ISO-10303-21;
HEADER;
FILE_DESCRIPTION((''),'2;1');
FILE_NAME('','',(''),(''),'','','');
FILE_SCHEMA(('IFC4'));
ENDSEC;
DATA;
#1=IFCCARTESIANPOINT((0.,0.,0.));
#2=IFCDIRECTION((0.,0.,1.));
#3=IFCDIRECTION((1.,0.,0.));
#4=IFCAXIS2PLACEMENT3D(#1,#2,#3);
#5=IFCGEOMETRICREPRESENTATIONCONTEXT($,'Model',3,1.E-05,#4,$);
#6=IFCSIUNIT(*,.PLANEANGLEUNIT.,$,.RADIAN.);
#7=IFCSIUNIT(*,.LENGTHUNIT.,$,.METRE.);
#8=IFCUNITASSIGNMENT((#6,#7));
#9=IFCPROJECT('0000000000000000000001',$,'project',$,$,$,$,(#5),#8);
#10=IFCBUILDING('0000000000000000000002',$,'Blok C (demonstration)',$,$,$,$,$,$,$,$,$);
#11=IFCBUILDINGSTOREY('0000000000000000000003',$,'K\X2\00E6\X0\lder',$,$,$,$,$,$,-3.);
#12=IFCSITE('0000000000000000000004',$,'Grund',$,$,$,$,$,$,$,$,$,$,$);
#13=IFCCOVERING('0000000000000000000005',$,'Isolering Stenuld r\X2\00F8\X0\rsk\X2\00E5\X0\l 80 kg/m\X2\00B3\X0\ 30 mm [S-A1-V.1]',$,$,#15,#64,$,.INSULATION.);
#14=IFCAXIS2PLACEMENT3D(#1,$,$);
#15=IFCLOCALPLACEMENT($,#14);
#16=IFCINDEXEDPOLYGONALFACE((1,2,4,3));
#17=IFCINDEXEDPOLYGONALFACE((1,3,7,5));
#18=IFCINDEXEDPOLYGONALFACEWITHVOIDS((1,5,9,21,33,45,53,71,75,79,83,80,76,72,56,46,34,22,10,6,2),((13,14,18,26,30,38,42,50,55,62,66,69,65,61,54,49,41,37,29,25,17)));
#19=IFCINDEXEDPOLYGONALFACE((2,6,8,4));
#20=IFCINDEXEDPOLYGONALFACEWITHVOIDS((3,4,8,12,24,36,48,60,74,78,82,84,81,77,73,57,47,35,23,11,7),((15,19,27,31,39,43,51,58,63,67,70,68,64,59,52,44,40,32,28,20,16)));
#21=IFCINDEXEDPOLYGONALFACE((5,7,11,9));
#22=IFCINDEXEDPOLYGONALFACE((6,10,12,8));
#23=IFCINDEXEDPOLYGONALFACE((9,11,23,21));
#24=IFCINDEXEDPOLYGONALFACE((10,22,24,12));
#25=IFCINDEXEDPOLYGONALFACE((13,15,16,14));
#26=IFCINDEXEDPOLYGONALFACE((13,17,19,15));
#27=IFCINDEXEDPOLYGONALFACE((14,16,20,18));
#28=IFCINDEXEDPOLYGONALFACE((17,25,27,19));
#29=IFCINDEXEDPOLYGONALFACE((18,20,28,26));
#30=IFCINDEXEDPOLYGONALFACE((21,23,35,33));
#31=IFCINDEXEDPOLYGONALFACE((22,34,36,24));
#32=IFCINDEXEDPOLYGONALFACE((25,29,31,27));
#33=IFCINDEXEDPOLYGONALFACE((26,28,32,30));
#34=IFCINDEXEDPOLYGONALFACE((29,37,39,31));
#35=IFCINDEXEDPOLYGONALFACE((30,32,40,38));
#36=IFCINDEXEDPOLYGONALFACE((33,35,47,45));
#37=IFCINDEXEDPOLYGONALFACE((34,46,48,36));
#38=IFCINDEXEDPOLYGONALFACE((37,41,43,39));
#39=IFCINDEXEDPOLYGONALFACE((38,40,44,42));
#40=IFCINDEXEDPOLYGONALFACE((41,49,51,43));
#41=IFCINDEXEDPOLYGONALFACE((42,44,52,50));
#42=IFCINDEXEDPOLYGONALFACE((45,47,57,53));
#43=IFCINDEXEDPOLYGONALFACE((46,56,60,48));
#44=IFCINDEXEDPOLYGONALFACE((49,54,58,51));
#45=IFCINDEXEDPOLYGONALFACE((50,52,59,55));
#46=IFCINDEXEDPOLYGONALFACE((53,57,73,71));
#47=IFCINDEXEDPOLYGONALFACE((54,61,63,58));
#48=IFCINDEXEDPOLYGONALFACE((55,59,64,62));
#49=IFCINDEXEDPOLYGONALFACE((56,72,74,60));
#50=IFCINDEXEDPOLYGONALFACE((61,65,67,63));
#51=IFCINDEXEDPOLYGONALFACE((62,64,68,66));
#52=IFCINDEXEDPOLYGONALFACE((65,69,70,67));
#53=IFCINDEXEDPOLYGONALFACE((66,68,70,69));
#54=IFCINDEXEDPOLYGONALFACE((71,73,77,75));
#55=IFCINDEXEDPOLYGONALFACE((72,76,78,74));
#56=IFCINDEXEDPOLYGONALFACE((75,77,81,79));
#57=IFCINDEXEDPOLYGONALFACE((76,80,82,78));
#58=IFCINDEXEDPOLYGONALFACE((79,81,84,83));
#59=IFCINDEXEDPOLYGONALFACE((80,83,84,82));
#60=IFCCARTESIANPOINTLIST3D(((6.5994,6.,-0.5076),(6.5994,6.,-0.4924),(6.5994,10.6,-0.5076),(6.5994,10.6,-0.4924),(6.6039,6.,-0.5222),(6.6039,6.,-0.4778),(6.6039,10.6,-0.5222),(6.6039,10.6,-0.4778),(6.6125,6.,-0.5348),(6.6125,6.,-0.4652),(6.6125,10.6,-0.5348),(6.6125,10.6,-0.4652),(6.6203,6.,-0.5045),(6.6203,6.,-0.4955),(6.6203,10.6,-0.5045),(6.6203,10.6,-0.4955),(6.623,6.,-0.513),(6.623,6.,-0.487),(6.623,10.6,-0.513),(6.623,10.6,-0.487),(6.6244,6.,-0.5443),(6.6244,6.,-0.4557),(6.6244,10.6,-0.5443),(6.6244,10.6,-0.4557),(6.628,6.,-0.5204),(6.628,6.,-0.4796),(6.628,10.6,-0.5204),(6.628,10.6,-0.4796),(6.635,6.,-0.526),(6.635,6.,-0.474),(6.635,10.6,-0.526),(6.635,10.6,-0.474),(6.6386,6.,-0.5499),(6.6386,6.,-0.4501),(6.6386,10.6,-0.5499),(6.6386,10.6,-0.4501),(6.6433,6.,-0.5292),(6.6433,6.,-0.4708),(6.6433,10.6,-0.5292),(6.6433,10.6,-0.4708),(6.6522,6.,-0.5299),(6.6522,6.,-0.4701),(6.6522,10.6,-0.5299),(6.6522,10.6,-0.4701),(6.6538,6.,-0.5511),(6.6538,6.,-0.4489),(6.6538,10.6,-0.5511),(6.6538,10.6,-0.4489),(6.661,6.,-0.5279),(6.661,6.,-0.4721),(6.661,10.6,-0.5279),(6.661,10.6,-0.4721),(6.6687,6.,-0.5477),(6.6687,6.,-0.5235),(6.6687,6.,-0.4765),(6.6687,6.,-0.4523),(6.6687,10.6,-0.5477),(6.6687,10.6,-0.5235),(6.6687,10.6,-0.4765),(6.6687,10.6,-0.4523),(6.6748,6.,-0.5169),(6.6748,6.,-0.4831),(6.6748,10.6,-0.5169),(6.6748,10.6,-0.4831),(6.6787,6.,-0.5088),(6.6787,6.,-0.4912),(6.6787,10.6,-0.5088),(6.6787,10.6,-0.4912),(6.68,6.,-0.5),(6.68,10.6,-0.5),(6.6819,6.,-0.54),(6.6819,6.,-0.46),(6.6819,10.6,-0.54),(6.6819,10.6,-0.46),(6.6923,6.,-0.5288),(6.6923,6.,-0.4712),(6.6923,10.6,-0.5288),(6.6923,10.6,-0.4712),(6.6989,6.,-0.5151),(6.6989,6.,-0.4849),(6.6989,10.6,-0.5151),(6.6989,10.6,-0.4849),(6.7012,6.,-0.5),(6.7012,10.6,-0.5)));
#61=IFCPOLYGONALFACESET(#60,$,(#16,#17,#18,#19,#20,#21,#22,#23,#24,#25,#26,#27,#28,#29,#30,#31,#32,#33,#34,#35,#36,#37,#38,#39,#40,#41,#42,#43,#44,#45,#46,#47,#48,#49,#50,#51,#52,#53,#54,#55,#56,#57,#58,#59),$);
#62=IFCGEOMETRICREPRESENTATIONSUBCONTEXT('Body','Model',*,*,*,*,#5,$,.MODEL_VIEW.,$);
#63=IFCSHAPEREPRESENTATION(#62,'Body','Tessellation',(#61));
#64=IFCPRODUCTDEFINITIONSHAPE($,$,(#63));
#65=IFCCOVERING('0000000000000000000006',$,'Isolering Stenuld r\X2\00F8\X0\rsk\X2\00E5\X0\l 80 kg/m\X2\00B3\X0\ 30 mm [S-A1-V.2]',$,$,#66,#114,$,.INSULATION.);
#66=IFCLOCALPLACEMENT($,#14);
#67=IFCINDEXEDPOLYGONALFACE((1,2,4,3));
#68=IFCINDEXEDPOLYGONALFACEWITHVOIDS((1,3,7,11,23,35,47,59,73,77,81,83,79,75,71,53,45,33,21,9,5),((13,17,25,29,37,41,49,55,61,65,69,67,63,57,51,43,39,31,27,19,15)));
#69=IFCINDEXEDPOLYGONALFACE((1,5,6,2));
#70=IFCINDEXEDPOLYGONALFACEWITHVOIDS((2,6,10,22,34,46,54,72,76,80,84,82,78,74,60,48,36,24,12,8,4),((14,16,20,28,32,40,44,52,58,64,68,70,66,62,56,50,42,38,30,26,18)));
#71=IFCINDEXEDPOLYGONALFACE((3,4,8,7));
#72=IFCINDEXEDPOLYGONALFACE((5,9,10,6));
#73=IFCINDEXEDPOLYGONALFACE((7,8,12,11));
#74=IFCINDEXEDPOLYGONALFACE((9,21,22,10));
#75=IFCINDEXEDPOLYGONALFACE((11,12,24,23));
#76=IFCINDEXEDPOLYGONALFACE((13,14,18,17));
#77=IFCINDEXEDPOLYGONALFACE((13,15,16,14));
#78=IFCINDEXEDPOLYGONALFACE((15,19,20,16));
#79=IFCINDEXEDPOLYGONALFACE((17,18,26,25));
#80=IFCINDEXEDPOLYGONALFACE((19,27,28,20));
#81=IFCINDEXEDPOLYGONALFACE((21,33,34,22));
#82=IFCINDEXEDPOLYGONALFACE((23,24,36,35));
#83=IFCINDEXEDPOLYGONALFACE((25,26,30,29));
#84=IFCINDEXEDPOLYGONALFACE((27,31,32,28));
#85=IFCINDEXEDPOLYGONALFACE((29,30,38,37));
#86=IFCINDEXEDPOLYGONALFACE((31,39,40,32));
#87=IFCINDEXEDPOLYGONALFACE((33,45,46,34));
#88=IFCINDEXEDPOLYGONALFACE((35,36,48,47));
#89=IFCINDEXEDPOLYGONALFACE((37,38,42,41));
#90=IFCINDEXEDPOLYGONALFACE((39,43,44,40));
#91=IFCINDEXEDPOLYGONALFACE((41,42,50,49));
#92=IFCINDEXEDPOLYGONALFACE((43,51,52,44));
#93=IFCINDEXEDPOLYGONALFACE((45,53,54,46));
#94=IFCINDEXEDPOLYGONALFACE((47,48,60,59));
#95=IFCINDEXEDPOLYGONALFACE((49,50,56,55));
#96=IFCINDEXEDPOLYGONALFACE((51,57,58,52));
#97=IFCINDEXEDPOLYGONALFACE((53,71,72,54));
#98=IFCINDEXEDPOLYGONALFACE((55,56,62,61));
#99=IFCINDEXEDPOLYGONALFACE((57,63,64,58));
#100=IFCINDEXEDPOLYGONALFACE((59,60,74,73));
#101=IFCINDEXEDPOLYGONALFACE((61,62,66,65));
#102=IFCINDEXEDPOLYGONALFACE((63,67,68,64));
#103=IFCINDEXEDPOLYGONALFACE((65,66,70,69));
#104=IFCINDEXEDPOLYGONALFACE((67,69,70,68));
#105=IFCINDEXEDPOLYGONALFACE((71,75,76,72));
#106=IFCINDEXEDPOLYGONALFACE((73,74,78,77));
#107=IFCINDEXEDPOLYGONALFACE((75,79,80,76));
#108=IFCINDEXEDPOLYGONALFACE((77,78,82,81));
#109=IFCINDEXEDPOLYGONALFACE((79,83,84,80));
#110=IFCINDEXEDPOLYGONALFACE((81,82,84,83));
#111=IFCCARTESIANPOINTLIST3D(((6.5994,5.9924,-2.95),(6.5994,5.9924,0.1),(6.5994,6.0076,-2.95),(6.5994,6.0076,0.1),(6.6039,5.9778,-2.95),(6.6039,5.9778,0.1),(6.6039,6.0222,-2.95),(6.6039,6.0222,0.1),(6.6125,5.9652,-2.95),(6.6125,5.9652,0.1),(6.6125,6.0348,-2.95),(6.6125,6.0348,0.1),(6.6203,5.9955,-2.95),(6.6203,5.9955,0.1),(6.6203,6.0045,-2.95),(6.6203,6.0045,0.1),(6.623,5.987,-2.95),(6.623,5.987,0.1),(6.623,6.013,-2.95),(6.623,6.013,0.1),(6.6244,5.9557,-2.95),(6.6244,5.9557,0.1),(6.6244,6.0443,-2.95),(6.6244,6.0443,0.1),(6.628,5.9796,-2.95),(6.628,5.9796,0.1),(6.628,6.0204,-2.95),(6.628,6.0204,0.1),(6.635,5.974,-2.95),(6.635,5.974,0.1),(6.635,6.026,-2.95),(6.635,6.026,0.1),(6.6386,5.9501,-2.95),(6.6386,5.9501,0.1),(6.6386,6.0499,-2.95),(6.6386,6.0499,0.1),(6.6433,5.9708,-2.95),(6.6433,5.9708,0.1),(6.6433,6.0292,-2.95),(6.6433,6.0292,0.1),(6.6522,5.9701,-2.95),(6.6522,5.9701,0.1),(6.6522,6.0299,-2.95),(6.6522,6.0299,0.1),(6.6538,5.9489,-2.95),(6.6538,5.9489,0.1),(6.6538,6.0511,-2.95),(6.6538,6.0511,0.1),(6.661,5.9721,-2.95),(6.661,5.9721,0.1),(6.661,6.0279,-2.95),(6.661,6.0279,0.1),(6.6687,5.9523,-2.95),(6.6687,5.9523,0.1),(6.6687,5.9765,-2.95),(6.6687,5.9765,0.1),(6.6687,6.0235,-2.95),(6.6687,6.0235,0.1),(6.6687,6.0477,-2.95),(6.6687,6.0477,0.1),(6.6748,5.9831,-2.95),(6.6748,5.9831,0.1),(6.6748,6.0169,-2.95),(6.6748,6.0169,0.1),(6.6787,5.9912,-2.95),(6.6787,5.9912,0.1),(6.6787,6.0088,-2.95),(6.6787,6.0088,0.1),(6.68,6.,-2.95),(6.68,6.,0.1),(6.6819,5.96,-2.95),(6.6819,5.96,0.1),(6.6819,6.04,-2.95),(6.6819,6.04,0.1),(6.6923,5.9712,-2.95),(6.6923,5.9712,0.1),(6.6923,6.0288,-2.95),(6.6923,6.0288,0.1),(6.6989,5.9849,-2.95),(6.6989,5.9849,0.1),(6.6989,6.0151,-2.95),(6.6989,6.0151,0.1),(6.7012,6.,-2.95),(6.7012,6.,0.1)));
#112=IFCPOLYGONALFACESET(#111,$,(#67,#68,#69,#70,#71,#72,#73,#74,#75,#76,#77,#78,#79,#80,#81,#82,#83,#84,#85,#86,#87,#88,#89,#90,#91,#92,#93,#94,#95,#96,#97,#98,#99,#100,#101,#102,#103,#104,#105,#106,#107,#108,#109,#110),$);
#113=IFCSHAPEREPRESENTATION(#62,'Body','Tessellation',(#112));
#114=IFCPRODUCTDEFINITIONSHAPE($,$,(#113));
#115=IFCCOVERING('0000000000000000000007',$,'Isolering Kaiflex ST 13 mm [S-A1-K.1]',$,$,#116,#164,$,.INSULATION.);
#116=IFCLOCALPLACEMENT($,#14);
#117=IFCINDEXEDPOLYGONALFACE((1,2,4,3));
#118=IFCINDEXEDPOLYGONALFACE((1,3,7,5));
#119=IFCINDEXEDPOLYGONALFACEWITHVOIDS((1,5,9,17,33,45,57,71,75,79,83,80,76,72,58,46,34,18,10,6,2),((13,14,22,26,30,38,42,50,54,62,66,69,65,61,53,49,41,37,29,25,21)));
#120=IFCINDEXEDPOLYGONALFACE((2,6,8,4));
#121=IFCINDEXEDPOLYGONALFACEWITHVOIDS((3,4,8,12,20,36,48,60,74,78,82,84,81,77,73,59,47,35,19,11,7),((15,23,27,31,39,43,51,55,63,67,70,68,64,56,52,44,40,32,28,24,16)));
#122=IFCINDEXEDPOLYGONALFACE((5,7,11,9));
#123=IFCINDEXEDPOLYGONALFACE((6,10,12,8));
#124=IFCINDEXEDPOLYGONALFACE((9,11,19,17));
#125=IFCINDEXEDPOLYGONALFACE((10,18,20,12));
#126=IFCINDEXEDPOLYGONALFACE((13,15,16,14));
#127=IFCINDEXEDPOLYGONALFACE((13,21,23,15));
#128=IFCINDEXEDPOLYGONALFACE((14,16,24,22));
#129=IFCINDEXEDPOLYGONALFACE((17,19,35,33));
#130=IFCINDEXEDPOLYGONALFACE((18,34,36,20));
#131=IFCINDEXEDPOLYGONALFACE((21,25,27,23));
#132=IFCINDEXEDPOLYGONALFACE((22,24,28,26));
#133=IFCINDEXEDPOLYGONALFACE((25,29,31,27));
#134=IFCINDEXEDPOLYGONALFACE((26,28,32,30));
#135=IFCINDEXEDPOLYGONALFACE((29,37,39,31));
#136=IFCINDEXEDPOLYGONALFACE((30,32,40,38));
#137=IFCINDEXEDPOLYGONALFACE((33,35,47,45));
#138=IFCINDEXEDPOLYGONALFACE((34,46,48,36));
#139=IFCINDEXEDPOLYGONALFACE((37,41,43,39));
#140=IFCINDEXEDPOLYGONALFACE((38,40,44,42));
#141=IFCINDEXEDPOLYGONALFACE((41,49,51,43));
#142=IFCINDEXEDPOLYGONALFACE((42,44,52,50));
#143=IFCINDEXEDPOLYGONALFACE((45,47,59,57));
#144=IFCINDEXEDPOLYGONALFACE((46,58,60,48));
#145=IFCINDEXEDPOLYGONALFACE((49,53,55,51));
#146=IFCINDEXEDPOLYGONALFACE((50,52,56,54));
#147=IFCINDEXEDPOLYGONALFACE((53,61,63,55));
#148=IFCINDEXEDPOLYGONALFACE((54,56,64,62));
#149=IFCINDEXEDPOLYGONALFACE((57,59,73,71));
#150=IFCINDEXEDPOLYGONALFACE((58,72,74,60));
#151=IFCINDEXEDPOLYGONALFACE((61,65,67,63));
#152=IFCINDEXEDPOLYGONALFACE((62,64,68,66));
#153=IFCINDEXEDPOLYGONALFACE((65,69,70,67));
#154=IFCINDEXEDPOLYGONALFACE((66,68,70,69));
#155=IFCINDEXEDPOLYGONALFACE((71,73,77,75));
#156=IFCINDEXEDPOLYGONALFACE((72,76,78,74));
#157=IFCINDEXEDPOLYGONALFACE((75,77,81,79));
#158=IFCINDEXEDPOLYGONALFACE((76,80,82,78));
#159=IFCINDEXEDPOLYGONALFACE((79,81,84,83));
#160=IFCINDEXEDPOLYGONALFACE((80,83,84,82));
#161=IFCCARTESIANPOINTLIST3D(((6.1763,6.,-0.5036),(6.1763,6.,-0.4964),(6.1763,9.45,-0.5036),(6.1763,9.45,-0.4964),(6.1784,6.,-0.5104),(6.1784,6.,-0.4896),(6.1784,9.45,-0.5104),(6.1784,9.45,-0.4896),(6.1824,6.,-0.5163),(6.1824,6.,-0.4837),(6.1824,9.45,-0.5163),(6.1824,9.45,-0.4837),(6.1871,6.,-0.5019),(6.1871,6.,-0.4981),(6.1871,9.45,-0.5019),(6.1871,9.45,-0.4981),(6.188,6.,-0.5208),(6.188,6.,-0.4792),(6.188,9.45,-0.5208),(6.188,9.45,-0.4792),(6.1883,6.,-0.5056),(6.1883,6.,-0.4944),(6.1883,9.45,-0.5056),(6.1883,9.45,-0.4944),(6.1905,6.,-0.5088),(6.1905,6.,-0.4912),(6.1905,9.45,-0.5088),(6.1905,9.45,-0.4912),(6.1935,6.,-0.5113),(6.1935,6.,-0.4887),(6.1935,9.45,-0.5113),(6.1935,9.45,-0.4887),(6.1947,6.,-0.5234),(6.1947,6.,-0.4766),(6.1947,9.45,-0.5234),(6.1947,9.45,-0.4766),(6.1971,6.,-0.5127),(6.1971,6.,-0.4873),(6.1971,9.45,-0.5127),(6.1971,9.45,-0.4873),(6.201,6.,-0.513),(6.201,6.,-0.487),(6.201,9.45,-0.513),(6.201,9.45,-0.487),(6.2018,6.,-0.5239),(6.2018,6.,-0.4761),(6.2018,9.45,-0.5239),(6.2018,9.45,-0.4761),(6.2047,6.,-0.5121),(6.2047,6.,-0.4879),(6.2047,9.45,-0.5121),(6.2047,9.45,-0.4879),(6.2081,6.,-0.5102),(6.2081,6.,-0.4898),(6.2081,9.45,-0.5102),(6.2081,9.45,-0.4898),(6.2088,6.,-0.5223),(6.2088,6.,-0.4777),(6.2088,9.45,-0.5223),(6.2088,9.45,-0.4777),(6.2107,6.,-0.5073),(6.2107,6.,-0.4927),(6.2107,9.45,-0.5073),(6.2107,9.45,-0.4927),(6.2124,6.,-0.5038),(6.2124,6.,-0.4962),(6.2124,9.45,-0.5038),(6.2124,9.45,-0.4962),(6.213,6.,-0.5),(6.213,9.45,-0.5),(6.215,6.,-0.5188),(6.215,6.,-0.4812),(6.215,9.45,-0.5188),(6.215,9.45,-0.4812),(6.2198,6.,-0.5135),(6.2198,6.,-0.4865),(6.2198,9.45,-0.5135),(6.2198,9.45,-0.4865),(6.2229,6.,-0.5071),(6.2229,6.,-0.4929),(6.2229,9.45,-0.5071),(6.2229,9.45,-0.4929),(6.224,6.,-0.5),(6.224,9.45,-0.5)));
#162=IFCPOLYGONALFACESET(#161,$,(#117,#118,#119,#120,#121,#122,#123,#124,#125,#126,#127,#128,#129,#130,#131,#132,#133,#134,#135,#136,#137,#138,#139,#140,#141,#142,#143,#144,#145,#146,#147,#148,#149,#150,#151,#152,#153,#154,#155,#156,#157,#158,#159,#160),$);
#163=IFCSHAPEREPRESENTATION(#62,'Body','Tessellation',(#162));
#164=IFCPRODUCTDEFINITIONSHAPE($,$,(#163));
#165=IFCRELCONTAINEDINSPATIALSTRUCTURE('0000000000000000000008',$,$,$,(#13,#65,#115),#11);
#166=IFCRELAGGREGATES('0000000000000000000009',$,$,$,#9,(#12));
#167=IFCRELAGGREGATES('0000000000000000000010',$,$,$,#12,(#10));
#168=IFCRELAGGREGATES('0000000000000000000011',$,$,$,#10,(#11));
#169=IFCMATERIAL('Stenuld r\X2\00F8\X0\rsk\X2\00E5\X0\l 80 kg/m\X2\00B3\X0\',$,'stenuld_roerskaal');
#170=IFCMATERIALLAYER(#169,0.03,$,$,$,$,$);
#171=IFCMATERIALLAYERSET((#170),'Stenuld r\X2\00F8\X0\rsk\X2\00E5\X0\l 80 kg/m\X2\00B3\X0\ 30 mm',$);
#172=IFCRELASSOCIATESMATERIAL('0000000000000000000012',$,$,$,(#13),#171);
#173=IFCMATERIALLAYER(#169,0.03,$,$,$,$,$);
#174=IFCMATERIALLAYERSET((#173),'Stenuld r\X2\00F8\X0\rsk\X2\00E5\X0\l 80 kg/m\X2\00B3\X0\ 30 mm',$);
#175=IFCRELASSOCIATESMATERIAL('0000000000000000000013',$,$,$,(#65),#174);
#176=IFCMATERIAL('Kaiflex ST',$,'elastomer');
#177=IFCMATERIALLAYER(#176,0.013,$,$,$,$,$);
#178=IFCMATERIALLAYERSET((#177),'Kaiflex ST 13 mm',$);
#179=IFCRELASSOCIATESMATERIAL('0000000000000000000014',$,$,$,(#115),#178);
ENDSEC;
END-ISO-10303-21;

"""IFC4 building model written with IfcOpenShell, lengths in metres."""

from ifc_helpers import new_model, si_unit, frame, origin_with_axes, place, context, subcontext, project, spatial, hollow_circle, extrude, material, layer, layer_set, element, save


model = new_model("IFC4")

# Units and contexts
model_context = context("Model", 3, precision=1e-05, world=origin_with_axes())
body_context = subcontext(model_context, "Body", "Model", "MODEL_VIEW")
ifc_project = project(units=[si_unit("PLANEANGLEUNIT", "RADIAN"), si_unit("LENGTHUNIT", "METRE")], contexts=[model_context])

# Site, building, storey
site = spatial("IfcSite", under=ifc_project, Name="Grund")
building = spatial("IfcBuilding", under=site, Name="Blok C (demonstration)")
storey = spatial("IfcBuildingStorey", under=building, Name="Kælder", Elevation=-3.0)

# Coverings
ifc_material_1 = material(Name="Stenuld rørskål 80 kg/m³", Category="stenuld_roerskaal")
ifc_layer_1 = layer(ifc_material_1, 0.03)
ifc_layer_set_1 = layer_set([ifc_layer_1], Name="Stenuld rørskål 80 kg/m³ 30 mm")
covering_1_placement = place(None, origin_with_axes())
element("IfcCovering", 1, at=covering_1_placement, inside=storey, material=ifc_layer_set_1, Name="Isolering Stenuld rørskål 80 kg/m³ 30 mm [S-A1-V.1]", PredefinedType="INSULATION", context=body_context, shape_type="SweptSolid", body=[
    extrude(hollow_circle(Radius=0.0512, WallThickness=0.0212), frame((6.65, 10.6, -0.5), z_axis=(0.0, -1.0, 0.0), x_axis=(1.0, 0.0, 0.0)), (0.0, 0.0, 1.0), 4.6),
])
ifc_layer_2 = layer(ifc_material_1, 0.03)
ifc_layer_set_2 = layer_set([ifc_layer_2], Name="Stenuld rørskål 80 kg/m³ 30 mm")
covering_2_placement = place(None, origin_with_axes())
element("IfcCovering", 2, at=covering_2_placement, inside=storey, material=ifc_layer_set_2, Name="Isolering Stenuld rørskål 80 kg/m³ 30 mm [S-A1-V.2]", PredefinedType="INSULATION", context=body_context, shape_type="SweptSolid", body=[
    extrude(hollow_circle(Radius=0.0512, WallThickness=0.0212), frame((6.65, 6.0, -2.95), z_axis=(0.0, 0.0, 1.0), x_axis=(1.0, 0.0, 0.0)), (0.0, 0.0, 1.0), 3.05),
])
ifc_material_2 = material(Name="Kaiflex ST", Category="elastomer")
ifc_layer_3 = layer(ifc_material_2, 0.013)
ifc_layer_set_3 = layer_set([ifc_layer_3], Name="Kaiflex ST 13 mm")
covering_3_placement = place(None, origin_with_axes())
element("IfcCovering", 3, at=covering_3_placement, inside=storey, material=ifc_layer_set_3, Name="Isolering Kaiflex ST 13 mm [S-A1-K.1]", PredefinedType="INSULATION", context=body_context, shape_type="SweptSolid", body=[
    extrude(hollow_circle(Radius=0.024, WallThickness=0.011), frame((6.2, 9.45, -0.5), z_axis=(0.0, -1.0, 0.0), x_axis=(1.0, 0.0, 0.0)), (0.0, 0.0, 1.0), 3.45),
])

save(model, "model.ifc")
